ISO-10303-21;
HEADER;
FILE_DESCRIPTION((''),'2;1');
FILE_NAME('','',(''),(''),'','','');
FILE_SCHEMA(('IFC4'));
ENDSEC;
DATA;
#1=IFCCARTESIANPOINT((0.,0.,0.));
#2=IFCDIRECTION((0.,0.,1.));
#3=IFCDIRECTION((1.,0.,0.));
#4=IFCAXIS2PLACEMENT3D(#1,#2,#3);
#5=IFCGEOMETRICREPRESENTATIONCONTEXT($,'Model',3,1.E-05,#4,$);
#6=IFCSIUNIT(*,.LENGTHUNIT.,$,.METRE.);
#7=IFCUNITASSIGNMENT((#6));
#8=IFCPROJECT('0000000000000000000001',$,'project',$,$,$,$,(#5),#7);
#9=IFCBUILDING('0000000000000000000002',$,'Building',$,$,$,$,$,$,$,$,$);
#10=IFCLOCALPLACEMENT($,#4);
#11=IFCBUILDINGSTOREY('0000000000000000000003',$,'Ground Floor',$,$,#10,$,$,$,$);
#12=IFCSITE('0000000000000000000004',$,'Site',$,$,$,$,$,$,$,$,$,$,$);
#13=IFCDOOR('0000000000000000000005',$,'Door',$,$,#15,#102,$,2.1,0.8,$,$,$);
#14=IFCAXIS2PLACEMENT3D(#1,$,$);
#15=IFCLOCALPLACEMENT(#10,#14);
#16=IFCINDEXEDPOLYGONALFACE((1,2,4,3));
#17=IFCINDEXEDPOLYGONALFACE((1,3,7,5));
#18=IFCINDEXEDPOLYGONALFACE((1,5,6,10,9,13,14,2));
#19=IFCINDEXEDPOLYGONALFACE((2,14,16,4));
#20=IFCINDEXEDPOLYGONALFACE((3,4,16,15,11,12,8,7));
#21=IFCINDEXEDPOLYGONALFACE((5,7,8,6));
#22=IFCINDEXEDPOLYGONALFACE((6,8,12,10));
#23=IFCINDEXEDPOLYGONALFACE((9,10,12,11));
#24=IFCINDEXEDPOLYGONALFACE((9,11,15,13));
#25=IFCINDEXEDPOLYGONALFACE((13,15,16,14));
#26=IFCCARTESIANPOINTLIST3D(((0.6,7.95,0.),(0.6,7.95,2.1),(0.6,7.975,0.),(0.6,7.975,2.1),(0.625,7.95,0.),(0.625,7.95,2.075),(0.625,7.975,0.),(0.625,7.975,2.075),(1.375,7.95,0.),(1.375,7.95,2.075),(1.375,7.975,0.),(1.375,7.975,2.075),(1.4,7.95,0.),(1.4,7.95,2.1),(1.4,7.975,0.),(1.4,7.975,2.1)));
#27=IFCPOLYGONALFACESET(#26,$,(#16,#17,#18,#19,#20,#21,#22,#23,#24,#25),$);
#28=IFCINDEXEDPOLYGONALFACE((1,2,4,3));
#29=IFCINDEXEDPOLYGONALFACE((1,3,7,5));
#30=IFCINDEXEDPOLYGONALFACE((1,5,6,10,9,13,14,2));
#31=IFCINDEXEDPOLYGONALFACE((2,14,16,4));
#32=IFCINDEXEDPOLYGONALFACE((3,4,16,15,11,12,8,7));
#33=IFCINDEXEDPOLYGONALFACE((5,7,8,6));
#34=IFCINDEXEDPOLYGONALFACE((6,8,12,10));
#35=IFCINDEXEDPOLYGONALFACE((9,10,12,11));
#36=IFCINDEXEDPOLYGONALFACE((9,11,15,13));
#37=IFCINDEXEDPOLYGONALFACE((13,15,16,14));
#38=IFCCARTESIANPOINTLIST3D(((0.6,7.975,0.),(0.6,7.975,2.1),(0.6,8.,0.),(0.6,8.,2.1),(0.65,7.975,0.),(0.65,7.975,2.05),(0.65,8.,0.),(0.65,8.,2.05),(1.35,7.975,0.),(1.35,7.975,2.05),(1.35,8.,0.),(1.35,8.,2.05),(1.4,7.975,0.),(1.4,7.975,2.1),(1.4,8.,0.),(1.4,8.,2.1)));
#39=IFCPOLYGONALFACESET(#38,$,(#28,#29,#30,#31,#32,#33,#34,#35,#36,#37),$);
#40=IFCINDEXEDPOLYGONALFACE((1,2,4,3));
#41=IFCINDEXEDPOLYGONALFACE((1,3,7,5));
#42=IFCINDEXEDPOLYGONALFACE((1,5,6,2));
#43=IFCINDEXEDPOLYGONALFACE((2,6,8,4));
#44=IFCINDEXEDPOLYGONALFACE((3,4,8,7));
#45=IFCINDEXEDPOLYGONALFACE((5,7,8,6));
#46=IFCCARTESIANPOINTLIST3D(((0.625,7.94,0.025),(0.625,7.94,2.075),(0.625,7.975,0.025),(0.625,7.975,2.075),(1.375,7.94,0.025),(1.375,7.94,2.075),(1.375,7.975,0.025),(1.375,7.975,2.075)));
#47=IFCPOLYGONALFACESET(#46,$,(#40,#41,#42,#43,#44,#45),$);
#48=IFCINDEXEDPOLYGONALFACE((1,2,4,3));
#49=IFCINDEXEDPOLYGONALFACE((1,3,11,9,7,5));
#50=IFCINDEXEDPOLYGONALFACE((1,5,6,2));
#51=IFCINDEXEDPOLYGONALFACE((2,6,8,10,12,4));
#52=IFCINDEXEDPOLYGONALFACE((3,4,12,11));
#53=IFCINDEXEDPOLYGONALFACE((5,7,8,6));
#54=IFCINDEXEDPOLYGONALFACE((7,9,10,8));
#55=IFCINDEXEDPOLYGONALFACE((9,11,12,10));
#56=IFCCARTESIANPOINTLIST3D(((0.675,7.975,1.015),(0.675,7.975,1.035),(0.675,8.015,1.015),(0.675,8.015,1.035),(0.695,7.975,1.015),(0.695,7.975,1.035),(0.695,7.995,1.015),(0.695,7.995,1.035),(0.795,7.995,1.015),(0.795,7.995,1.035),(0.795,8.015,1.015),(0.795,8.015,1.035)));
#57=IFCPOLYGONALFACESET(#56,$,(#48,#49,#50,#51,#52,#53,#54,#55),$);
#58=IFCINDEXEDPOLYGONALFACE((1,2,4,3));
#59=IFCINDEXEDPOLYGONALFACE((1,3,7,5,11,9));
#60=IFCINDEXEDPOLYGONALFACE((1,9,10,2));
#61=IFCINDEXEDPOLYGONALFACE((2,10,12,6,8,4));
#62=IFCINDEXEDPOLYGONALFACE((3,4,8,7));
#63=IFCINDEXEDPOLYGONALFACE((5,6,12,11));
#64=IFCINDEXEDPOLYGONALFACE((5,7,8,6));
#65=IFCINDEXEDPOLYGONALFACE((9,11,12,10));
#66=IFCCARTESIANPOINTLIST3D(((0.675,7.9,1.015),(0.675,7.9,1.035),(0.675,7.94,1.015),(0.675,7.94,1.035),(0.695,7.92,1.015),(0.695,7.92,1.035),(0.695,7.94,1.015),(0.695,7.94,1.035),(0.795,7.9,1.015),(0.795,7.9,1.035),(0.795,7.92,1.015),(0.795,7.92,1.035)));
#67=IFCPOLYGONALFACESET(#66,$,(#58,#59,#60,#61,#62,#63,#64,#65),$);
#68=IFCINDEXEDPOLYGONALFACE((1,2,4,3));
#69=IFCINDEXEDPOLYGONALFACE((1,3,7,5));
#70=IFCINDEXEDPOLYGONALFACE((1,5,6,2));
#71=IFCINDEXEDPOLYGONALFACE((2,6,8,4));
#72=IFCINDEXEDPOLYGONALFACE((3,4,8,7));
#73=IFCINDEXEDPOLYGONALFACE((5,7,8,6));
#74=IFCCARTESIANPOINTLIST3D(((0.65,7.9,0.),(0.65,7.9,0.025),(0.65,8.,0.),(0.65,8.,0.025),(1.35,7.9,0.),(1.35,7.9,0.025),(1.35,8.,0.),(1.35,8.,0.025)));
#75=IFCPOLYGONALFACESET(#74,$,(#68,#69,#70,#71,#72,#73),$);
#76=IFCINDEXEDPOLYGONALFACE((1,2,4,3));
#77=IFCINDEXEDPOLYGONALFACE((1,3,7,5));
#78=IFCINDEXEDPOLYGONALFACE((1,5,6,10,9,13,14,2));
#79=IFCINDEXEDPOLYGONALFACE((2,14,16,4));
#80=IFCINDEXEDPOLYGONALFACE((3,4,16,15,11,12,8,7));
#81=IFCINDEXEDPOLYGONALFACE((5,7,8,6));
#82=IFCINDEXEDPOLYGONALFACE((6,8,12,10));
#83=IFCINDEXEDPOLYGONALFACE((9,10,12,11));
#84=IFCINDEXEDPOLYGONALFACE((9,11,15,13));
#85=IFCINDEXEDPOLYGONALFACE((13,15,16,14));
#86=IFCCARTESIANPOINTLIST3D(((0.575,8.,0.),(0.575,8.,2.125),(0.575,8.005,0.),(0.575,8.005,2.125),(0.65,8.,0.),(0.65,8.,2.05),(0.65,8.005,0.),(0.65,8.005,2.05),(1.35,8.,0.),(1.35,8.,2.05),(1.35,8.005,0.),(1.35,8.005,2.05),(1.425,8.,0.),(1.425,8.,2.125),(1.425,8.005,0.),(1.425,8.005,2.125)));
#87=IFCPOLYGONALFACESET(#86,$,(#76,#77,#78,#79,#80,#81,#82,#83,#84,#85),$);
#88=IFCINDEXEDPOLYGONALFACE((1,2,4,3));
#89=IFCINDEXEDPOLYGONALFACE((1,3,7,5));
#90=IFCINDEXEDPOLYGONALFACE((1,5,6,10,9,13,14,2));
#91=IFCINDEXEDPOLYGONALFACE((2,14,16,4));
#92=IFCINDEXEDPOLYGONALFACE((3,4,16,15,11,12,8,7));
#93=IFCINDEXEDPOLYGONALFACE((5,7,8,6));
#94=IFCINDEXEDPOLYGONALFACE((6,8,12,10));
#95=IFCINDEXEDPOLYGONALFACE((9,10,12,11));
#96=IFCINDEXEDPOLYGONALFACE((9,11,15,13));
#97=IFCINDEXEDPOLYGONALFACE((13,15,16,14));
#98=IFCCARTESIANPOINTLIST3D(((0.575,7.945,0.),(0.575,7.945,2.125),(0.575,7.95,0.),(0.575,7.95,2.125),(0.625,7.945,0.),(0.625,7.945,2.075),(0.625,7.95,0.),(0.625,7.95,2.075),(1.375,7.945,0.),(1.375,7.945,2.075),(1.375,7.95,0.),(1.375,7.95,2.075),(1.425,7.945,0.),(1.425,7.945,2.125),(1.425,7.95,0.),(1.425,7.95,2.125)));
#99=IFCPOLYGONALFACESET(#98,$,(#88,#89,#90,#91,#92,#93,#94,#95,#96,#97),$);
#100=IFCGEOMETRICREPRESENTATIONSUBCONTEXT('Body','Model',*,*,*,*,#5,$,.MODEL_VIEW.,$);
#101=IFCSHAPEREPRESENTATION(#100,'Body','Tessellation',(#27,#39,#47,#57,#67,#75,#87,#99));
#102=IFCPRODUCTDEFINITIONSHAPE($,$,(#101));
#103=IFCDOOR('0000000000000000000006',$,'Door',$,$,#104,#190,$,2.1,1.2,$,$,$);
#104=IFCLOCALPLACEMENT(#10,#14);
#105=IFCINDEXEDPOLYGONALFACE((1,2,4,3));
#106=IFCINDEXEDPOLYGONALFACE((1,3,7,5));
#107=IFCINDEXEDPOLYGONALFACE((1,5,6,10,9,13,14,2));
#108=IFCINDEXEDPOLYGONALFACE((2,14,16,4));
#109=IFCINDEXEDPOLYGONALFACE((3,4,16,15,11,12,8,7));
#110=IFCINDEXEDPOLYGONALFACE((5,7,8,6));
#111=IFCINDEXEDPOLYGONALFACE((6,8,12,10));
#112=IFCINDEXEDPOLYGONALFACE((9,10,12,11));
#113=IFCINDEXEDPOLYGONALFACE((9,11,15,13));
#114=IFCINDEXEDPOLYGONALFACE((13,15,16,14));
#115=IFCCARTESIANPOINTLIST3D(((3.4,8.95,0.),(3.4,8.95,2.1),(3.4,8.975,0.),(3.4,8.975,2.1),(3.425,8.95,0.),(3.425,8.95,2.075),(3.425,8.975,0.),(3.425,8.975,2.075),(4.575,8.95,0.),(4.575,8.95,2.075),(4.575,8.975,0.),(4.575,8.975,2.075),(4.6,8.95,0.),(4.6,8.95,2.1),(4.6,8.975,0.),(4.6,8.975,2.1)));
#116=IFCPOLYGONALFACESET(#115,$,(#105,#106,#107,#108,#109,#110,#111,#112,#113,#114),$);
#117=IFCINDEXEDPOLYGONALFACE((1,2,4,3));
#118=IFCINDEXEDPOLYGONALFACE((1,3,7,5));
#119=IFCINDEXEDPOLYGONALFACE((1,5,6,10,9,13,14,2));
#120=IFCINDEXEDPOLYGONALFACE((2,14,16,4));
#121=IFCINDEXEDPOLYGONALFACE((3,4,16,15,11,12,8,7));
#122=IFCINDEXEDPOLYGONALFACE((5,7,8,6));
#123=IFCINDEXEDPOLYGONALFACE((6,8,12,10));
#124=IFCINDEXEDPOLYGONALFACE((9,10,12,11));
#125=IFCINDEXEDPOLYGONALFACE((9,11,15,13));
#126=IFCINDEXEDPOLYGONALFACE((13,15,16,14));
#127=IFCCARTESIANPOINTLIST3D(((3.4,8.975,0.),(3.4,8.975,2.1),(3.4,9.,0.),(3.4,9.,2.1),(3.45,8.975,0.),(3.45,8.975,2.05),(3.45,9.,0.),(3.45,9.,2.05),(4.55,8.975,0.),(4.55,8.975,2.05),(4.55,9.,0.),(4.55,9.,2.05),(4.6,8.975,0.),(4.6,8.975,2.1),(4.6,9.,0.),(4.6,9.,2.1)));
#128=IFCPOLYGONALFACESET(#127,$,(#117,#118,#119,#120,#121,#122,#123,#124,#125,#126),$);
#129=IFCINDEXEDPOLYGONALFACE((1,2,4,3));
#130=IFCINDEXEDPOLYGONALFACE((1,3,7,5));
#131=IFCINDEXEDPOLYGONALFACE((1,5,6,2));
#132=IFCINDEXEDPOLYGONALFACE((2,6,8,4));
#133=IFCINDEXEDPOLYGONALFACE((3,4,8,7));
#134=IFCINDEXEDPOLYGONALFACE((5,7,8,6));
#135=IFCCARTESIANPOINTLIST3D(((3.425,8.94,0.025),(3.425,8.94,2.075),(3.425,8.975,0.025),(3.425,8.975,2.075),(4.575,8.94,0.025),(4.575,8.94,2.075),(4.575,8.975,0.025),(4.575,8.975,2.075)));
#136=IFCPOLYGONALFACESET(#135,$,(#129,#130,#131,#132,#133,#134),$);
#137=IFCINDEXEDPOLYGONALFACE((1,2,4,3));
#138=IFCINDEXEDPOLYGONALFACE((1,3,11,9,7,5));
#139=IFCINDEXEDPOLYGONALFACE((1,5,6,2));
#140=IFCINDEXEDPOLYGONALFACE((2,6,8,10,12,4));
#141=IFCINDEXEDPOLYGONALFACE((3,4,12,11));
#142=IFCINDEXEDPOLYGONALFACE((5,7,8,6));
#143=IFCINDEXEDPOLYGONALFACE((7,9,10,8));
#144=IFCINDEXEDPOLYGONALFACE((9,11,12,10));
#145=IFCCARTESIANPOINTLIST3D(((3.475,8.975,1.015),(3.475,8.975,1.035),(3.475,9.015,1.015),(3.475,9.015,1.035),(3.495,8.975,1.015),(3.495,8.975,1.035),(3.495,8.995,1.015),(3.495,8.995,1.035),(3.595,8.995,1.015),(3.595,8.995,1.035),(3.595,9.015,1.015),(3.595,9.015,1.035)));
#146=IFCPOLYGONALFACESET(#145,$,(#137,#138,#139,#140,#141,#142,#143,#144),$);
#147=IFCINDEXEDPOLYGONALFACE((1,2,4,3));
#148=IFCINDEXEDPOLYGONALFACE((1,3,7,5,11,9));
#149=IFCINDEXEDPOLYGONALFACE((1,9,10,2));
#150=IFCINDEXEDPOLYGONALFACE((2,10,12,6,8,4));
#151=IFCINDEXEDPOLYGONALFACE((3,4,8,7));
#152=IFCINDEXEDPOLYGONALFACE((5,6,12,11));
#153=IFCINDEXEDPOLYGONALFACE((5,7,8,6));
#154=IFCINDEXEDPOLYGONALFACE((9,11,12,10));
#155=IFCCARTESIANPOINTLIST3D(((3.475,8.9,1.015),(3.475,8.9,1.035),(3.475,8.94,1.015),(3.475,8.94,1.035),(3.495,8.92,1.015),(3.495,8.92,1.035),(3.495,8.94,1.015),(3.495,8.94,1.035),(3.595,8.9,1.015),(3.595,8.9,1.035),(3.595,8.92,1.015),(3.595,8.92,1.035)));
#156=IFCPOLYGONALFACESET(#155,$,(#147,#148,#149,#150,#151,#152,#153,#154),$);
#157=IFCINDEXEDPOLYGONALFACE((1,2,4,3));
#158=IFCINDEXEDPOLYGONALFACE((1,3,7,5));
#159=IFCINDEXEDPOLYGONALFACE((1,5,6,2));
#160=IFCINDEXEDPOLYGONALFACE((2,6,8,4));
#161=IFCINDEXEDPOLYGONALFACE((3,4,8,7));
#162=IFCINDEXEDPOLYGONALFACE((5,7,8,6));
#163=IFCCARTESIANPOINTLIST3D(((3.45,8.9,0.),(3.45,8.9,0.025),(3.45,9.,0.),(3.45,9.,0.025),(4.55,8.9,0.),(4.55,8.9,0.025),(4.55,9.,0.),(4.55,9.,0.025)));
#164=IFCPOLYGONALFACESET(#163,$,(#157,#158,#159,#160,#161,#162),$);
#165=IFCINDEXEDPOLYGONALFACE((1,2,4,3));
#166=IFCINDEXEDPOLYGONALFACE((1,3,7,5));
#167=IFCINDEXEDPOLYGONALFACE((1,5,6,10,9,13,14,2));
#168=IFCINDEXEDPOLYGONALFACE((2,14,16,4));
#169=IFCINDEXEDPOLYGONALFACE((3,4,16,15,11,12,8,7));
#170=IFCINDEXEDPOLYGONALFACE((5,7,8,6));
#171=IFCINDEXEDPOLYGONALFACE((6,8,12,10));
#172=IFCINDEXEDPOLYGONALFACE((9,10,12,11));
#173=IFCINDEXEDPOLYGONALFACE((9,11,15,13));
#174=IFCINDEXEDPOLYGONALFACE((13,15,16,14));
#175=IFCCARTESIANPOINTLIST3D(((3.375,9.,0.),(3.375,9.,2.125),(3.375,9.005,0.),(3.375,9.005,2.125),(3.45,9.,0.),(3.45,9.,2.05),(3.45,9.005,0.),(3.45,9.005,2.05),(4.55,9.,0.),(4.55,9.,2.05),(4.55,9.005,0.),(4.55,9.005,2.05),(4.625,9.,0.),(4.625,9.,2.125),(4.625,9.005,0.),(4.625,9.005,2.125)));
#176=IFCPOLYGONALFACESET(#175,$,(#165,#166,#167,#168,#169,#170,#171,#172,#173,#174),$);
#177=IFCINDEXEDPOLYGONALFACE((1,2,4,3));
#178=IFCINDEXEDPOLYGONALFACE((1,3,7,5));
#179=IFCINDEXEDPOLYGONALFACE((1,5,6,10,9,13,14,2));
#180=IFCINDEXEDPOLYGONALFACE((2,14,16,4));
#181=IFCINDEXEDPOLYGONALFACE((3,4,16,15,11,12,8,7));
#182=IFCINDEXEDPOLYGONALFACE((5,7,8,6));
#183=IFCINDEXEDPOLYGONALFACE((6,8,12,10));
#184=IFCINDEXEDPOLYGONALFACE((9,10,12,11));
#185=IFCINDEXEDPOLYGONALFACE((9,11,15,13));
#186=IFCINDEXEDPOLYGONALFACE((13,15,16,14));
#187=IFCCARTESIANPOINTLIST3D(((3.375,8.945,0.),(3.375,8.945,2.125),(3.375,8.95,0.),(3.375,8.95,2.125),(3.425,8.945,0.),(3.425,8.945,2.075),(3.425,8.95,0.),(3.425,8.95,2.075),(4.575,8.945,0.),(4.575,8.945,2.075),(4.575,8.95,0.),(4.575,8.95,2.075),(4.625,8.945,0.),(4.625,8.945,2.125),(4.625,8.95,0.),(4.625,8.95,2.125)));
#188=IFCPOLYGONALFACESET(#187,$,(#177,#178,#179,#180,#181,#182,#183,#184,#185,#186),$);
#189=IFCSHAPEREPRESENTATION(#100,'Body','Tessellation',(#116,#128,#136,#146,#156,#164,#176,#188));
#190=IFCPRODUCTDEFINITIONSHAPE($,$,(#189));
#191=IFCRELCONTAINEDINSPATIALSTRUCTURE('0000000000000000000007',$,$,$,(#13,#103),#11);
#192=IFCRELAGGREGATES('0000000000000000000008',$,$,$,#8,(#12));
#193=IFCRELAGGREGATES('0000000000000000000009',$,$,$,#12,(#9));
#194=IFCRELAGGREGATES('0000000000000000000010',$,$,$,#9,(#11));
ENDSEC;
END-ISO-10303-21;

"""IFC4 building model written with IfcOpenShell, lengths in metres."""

from ifc_helpers import new_model, si_unit, frame, origin_with_axes, place, context, subcontext, project, spatial, line, indexed_curve, outline, extrude, element, save


model = new_model("IFC4")

# Units and contexts
model_context = context("Model", 3, precision=1e-05, world=origin_with_axes())
body_context = subcontext(model_context, "Body", "Model", "MODEL_VIEW")
ifc_project = project(units=[si_unit("LENGTHUNIT", "METRE")], contexts=[model_context])

# Site, building, storey
site = spatial("IfcSite", under=ifc_project, Name="Site")
building = spatial("IfcBuilding", under=site, Name="Building")
storey_placement = place(None, origin_with_axes())
storey = spatial("IfcBuildingStorey", under=building, at=storey_placement, Name="Ground Floor")

# Doors
door_1_placement = place(storey_placement, frame((1.4, 8.0, 0.0), z_axis=(0.0, 0.0, 1.0), x_axis=(-1.0, 0.0, 0.0)))
element("IfcDoor", 1, at=door_1_placement, inside=storey, Name="Door", OverallHeight=2.1, OverallWidth=0.8, context=body_context, shape_type="SweptSolid", body=[
    extrude(outline(indexed_curve([(0.0, 0.0), (0.0, 2.1), (0.8, 2.1), (0.8, 0.0), (0.775, 0.0), (0.775, 2.075), (0.025, 2.075), (0.025, 0.0)], segments=[line(1, 2, 3, 4, 5, 6, 7, 8, 1)])), frame((0.0, 0.025, 0.0), z_axis=(0.0, -1.0, 0.0), x_axis=(1.0, 0.0, 0.0)), (0.0, 0.0, -1.0), 0.025),
    extrude(outline(indexed_curve([(0.0, 0.0), (0.0, 2.1), (0.8, 2.1), (0.8, 0.0), (0.75, 0.0), (0.75, 2.05), (0.05, 2.05), (0.05, 0.0)], segments=[line(1, 2, 3, 4, 5, 6, 7, 8, 1)])), frame((0.0, 0.0, 0.0), z_axis=(0.0, -1.0, 0.0), x_axis=(1.0, 0.0, 0.0)), (0.0, 0.0, -1.0), 0.025),
    extrude(outline(indexed_curve([(0.0, 0.0), (0.75, 0.0), (0.75, 0.035), (0.0, 0.035)], segments=[line(1, 2, 3, 4, 1)])), frame((0.025, 0.025, 0.025), z_axis=(0.0, 0.0, 1.0), x_axis=(1.0, 0.0, 0.0)), (0.0, 0.0, 1.0), 2.05),
    extrude(outline(indexed_curve([(0.0, 0.0), (0.0, -0.04), (-0.12, -0.04), (-0.12, -0.02), (-0.02, -0.02), (-0.02, 0.0)], segments=[line(1, 2, 3, 4, 5, 6, 1)])), frame((0.725, 0.025, 1.015), z_axis=(0.0, 0.0, 1.0), x_axis=(1.0, 0.0, 0.0)), (0.0, 0.0, 1.0), 0.02),
    extrude(outline(indexed_curve([(0.0, 0.0), (0.0, 0.04), (-0.12, 0.04), (-0.12, 0.02), (-0.02, 0.02), (-0.02, 0.0)], segments=[line(1, 2, 3, 4, 5, 6, 1)])), frame((0.725, 0.06, 1.015), z_axis=(0.0, 0.0, 1.0), x_axis=(1.0, 0.0, 0.0)), (0.0, 0.0, 1.0), 0.02),
    extrude(outline(indexed_curve([(0.0, 0.0), (0.7, 0.0), (0.7, 0.1), (0.0, 0.1)], segments=[line(1, 2, 3, 4, 1)])), frame((0.05, 0.0, 0.0), z_axis=(0.0, 0.0, 1.0), x_axis=(1.0, 0.0, 0.0)), (0.0, 0.0, 1.0), 0.025),
    extrude(outline(indexed_curve([(0.0, 0.0), (0.0, 2.125), (0.85, 2.125), (0.85, 0.0), (0.775, 0.0), (0.775, 2.05), (0.075, 2.05), (0.075, 0.0)], segments=[line(1, 2, 3, 4, 5, 6, 7, 8, 1)])), frame((-0.025, -0.005, 0.0), z_axis=(0.0, -1.0, 0.0), x_axis=(1.0, 0.0, 0.0)), (0.0, 0.0, -1.0), 0.005),
    extrude(outline(indexed_curve([(0.0, 0.0), (0.0, 2.125), (0.85, 2.125), (0.85, 0.0), (0.8, 0.0), (0.8, 2.075), (0.05, 2.075), (0.05, 0.0)], segments=[line(1, 2, 3, 4, 5, 6, 7, 8, 1)])), frame((-0.025, 0.05, 0.0), z_axis=(0.0, -1.0, 0.0), x_axis=(1.0, 0.0, 0.0)), (0.0, 0.0, -1.0), 0.005),
])
door_2_placement = place(storey_placement, frame((4.6, 9.0, 0.0), z_axis=(0.0, 0.0, 1.0), x_axis=(-1.0, 0.0, 0.0)))
element("IfcDoor", 2, at=door_2_placement, inside=storey, Name="Door", OverallHeight=2.1, OverallWidth=1.2, context=body_context, shape_type="SweptSolid", body=[
    extrude(outline(indexed_curve([(0.0, 0.0), (0.0, 2.1), (1.2, 2.1), (1.2, 0.0), (1.175, 0.0), (1.175, 2.075), (0.025, 2.075), (0.025, 0.0)], segments=[line(1, 2, 3, 4, 5, 6, 7, 8, 1)])), frame((0.0, 0.025, 0.0), z_axis=(0.0, -1.0, 0.0), x_axis=(1.0, 0.0, 0.0)), (0.0, 0.0, -1.0), 0.025),
    extrude(outline(indexed_curve([(0.0, 0.0), (0.0, 2.1), (1.2, 2.1), (1.2, 0.0), (1.15, 0.0), (1.15, 2.05), (0.05, 2.05), (0.05, 0.0)], segments=[line(1, 2, 3, 4, 5, 6, 7, 8, 1)])), frame((0.0, 0.0, 0.0), z_axis=(0.0, -1.0, 0.0), x_axis=(1.0, 0.0, 0.0)), (0.0, 0.0, -1.0), 0.025),
    extrude(outline(indexed_curve([(0.0, 0.0), (1.15, 0.0), (1.15, 0.035), (0.0, 0.035)], segments=[line(1, 2, 3, 4, 1)])), frame((0.025, 0.025, 0.025), z_axis=(0.0, 0.0, 1.0), x_axis=(1.0, 0.0, 0.0)), (0.0, 0.0, 1.0), 2.05),
    extrude(outline(indexed_curve([(0.0, 0.0), (0.0, -0.04), (-0.12, -0.04), (-0.12, -0.02), (-0.02, -0.02), (-0.02, 0.0)], segments=[line(1, 2, 3, 4, 5, 6, 1)])), frame((1.125, 0.025, 1.015), z_axis=(0.0, 0.0, 1.0), x_axis=(1.0, 0.0, 0.0)), (0.0, 0.0, 1.0), 0.02),
    extrude(outline(indexed_curve([(0.0, 0.0), (0.0, 0.04), (-0.12, 0.04), (-0.12, 0.02), (-0.02, 0.02), (-0.02, 0.0)], segments=[line(1, 2, 3, 4, 5, 6, 1)])), frame((1.125, 0.06, 1.015), z_axis=(0.0, 0.0, 1.0), x_axis=(1.0, 0.0, 0.0)), (0.0, 0.0, 1.0), 0.02),
    extrude(outline(indexed_curve([(0.0, 0.0), (1.1, 0.0), (1.1, 0.1), (0.0, 0.1)], segments=[line(1, 2, 3, 4, 1)])), frame((0.05, 0.0, 0.0), z_axis=(0.0, 0.0, 1.0), x_axis=(1.0, 0.0, 0.0)), (0.0, 0.0, 1.0), 0.025),
    extrude(outline(indexed_curve([(0.0, 0.0), (0.0, 2.125), (1.25, 2.125), (1.25, 0.0), (1.175, 0.0), (1.175, 2.05), (0.075, 2.05), (0.075, 0.0)], segments=[line(1, 2, 3, 4, 5, 6, 7, 8, 1)])), frame((-0.025, -0.005, 0.0), z_axis=(0.0, -1.0, 0.0), x_axis=(1.0, 0.0, 0.0)), (0.0, 0.0, -1.0), 0.005),
    extrude(outline(indexed_curve([(0.0, 0.0), (0.0, 2.125), (1.25, 2.125), (1.25, 0.0), (1.2, 0.0), (1.2, 2.075), (0.05, 2.075), (0.05, 0.0)], segments=[line(1, 2, 3, 4, 5, 6, 7, 8, 1)])), frame((-0.025, 0.05, 0.0), z_axis=(0.0, -1.0, 0.0), x_axis=(1.0, 0.0, 0.0)), (0.0, 0.0, -1.0), 0.005),
])

save(model, "model.ifc")
